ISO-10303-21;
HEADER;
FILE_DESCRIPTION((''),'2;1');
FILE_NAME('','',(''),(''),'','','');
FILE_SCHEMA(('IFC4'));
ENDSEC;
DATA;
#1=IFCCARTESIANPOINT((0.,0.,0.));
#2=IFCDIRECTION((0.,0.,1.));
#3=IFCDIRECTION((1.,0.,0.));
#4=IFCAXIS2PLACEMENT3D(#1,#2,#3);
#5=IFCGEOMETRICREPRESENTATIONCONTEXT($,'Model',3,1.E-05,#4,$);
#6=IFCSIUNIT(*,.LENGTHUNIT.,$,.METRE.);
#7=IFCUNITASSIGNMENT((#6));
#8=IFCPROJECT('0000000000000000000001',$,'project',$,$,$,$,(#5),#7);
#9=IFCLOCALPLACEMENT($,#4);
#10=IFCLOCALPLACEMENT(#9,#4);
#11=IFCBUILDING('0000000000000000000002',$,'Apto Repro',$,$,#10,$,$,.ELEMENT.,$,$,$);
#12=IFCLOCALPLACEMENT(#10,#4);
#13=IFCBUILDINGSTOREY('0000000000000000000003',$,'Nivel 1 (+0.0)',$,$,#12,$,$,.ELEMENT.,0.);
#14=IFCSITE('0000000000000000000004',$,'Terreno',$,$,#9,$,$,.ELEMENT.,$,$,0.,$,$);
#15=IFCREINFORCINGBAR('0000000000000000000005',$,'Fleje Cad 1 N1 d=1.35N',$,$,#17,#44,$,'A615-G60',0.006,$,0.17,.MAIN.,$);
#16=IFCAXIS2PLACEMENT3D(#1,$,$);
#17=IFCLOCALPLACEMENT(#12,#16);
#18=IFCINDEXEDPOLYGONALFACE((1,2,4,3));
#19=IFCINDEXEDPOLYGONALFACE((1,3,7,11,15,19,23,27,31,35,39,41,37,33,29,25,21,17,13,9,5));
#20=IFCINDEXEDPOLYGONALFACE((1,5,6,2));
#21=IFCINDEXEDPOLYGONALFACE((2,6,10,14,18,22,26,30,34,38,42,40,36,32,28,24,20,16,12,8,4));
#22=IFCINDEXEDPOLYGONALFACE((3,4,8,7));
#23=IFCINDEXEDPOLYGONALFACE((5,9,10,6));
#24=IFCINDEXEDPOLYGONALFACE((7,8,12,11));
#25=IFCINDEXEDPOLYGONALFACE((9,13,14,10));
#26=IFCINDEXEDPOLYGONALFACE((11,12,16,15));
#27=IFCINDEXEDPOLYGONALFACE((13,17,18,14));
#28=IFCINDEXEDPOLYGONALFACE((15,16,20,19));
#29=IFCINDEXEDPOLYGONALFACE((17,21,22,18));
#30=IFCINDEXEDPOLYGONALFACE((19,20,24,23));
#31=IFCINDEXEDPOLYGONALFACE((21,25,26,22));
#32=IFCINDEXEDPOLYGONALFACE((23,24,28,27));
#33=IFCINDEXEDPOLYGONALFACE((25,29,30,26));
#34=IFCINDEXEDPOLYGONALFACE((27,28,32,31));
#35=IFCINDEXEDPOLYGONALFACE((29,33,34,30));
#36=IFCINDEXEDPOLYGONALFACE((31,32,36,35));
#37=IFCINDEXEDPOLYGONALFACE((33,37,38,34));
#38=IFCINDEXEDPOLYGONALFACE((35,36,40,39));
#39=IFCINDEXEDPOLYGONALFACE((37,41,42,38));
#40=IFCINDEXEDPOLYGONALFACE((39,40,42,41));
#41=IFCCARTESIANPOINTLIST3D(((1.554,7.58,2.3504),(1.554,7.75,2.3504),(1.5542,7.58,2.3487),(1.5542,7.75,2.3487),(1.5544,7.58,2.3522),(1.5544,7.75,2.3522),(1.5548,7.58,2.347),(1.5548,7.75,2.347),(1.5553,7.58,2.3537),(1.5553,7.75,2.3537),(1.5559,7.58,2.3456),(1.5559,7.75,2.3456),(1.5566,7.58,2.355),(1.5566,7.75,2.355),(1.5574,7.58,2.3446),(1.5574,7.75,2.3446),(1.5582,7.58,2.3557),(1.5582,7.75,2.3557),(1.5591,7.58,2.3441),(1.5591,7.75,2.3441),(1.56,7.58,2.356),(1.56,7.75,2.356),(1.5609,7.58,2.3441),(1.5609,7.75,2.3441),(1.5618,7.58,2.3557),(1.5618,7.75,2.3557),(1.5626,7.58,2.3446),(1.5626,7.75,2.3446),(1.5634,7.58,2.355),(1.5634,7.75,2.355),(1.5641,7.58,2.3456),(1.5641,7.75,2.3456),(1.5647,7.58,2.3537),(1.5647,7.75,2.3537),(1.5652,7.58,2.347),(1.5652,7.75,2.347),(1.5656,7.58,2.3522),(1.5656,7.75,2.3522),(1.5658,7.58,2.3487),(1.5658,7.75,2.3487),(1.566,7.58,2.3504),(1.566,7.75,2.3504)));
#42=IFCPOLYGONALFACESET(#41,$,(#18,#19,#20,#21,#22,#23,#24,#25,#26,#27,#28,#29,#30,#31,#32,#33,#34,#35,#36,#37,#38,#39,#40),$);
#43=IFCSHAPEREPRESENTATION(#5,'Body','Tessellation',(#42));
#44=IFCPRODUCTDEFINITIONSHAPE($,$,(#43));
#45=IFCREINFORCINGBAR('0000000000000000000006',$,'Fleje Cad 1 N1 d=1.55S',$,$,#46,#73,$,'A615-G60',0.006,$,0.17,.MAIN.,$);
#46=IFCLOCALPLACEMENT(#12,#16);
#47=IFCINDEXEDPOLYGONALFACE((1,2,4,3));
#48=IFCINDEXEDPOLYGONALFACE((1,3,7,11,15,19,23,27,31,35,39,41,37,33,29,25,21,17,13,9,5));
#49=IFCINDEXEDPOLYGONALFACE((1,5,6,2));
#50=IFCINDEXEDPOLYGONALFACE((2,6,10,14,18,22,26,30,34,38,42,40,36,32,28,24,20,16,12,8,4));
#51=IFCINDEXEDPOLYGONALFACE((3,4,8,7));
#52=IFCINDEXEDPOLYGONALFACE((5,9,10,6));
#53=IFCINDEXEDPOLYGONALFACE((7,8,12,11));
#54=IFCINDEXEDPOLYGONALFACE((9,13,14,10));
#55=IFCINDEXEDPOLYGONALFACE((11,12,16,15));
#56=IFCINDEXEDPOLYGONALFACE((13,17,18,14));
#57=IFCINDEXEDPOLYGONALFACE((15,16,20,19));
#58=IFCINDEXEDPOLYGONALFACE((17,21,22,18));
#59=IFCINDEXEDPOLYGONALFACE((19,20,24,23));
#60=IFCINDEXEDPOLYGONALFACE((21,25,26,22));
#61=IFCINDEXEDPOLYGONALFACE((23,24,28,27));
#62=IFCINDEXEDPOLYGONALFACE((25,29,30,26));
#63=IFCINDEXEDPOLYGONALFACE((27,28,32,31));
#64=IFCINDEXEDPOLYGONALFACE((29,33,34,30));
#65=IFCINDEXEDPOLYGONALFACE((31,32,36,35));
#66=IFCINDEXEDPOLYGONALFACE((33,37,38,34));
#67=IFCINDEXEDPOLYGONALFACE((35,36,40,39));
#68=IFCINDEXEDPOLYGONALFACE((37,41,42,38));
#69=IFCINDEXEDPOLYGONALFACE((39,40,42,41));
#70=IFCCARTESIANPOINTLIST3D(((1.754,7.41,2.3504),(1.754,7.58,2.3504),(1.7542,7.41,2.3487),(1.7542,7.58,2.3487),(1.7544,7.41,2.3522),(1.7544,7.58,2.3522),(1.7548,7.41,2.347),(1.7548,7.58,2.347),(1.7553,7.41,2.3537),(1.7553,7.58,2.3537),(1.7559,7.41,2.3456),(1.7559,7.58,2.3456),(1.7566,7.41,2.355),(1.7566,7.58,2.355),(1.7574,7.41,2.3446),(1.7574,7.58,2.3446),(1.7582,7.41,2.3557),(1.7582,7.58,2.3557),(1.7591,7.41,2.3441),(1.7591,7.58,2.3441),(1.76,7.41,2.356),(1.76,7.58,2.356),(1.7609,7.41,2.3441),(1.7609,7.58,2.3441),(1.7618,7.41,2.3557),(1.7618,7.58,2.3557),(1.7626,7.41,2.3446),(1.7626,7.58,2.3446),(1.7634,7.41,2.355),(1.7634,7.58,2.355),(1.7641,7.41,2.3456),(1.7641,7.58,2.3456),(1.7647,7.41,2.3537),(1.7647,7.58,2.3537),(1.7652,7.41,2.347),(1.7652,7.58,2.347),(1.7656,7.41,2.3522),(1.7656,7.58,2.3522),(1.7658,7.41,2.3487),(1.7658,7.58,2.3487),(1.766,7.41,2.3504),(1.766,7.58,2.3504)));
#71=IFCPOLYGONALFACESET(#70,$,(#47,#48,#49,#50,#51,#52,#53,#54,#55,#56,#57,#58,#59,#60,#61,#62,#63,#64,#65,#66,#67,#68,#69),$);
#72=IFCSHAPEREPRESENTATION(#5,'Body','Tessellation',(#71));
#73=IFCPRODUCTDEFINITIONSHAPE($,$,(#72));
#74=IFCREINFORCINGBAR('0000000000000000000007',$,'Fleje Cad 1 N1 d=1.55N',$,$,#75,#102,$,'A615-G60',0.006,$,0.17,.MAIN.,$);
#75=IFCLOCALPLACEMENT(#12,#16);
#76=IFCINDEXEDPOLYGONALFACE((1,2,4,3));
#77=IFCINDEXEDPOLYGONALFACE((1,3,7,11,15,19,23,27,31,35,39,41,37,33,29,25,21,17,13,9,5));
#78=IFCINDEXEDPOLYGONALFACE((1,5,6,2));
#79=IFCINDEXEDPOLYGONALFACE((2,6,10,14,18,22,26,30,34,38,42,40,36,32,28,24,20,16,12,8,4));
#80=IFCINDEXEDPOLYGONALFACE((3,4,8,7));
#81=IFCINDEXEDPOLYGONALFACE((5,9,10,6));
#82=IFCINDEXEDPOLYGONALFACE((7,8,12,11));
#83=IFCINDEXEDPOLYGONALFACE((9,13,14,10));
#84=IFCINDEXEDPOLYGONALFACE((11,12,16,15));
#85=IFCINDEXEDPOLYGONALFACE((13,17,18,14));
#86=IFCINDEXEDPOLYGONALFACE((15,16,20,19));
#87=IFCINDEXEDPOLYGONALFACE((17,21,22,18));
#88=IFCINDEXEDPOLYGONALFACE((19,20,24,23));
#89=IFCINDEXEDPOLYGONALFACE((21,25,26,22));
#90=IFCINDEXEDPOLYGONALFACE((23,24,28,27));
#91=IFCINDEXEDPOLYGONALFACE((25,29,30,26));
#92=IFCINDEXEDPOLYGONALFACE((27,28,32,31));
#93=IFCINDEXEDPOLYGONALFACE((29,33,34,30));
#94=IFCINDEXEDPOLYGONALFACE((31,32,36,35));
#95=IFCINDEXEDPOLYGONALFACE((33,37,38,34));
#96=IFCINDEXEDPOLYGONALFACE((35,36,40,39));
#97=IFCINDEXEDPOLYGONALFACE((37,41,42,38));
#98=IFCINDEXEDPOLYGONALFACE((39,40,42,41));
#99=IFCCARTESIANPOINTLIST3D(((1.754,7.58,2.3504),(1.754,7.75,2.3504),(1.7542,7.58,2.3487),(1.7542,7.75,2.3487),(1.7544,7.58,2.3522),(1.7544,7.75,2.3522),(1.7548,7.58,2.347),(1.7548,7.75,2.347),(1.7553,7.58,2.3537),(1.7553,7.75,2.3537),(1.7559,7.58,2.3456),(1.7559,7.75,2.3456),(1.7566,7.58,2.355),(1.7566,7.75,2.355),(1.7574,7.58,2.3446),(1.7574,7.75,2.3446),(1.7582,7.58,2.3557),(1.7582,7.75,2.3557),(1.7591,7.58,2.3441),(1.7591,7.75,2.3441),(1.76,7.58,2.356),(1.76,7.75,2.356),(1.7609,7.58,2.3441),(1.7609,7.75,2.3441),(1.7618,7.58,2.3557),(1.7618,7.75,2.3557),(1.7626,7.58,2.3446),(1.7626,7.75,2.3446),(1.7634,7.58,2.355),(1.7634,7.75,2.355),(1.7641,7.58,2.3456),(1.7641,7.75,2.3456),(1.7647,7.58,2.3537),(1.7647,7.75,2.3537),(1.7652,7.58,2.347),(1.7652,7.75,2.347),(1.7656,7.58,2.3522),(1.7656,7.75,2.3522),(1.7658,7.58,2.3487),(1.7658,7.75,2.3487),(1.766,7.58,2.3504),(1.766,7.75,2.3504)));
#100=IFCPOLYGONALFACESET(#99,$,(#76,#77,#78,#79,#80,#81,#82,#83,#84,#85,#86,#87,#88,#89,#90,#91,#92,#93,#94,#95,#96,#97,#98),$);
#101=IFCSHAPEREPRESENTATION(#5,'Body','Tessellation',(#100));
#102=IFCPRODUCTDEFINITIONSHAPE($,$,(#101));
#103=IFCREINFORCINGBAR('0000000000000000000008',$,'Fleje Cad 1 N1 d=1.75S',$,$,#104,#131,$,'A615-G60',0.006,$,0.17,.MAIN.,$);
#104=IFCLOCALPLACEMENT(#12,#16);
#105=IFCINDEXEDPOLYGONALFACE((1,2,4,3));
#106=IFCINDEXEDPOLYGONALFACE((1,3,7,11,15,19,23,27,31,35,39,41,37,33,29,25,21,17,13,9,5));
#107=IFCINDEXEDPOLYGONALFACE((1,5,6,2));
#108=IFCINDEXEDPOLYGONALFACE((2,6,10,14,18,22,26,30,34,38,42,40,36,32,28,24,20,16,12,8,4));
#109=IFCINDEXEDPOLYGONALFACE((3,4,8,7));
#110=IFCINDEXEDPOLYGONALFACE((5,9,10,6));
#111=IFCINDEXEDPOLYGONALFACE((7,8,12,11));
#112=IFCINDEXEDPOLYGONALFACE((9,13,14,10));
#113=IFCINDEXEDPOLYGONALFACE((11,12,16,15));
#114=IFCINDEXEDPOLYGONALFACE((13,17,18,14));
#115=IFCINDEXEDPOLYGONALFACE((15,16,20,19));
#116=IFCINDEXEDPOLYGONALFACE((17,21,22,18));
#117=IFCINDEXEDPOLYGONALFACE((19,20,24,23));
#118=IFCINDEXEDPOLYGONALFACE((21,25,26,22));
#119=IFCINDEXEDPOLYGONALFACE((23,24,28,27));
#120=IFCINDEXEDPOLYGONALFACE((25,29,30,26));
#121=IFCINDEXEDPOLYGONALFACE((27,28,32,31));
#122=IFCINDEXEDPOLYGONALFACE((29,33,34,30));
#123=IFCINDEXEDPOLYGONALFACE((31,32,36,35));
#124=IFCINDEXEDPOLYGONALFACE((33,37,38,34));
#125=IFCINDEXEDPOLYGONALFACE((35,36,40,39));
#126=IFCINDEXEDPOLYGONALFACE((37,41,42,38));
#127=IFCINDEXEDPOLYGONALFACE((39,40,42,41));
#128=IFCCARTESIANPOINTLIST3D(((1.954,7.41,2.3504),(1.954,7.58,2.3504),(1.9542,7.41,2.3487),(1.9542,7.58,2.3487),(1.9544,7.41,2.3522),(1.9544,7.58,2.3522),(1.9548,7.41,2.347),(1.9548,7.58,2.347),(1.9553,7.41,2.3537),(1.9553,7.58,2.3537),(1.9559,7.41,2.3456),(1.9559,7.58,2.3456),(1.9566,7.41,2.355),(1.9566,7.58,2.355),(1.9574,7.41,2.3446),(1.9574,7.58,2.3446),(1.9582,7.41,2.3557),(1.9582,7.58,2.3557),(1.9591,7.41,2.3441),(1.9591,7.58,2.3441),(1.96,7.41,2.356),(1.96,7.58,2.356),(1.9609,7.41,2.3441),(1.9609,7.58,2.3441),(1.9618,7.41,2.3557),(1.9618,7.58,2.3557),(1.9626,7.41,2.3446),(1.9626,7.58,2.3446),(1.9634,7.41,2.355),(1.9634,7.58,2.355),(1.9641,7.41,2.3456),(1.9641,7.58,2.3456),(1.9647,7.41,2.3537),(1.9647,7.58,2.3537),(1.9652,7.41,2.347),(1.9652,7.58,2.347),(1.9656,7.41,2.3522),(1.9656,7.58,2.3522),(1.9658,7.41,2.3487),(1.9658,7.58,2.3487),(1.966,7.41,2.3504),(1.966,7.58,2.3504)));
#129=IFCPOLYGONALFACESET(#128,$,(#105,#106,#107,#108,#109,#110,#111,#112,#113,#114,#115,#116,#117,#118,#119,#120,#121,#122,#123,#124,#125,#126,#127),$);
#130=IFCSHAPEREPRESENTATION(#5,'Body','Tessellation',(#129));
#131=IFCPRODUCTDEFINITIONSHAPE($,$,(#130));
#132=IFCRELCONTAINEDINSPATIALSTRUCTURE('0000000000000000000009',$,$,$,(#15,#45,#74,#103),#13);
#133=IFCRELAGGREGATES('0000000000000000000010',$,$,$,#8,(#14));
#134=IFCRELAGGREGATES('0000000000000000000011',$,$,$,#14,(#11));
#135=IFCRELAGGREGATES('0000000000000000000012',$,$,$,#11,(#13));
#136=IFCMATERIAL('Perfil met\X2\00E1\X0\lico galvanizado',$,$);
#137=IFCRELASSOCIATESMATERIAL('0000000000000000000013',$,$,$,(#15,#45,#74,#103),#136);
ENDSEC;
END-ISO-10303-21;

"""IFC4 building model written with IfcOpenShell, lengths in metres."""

from ifc_helpers import new_model, si_unit, frame, origin_with_axes, origin_2d_with_axis, place, context, project, spatial, circle, extrude, material, element, save


model = new_model("IFC4")

# Units and contexts
model_context = context("Model", 3, precision=1e-05, world=origin_with_axes())
ifc_project = project(units=[si_unit("LENGTHUNIT", "METRE")], contexts=[model_context])

# Site, building, storey
site_placement = place(None, origin_with_axes())
site = spatial("IfcSite", under=ifc_project, at=site_placement, Name="Terreno", CompositionType="ELEMENT", RefElevation=0.0)
building_placement = place(site_placement, origin_with_axes())
building = spatial("IfcBuilding", under=site, at=building_placement, Name="Apto Repro", CompositionType="ELEMENT")
storey_placement = place(building_placement, origin_with_axes())
storey = spatial("IfcBuildingStorey", under=building, at=storey_placement, Name="Nivel 1 (+0.0)", CompositionType="ELEMENT", Elevation=0.0)

# Reinforcing bars
ifc_material = material(Name="Perfil metálico galvanizado")
reinforcing_bar_1_placement = place(storey_placement, origin_with_axes())
element("IfcReinforcingBar", 1, at=reinforcing_bar_1_placement, inside=storey, material=ifc_material, Name="Fleje Cad 1 N1 d=1.35N", SteelGrade="A615-G60", BarLength=0.17, NominalDiameter=0.006, PredefinedType="MAIN", context=model_context, shape_type="SweptSolid", body=[
    extrude(circle(Radius=0.006, at=origin_2d_with_axis()), frame((1.56, 7.58, 2.35), z_axis=(0.0, 1.0, 0.0), x_axis=(0.0, 0.0, 1.0)), (0.0, 0.0, 1.0), 0.17),
])
reinforcing_bar_2_placement = place(storey_placement, origin_with_axes())
element("IfcReinforcingBar", 2, at=reinforcing_bar_2_placement, inside=storey, material=ifc_material, Name="Fleje Cad 1 N1 d=1.55S", SteelGrade="A615-G60", BarLength=0.17, NominalDiameter=0.006, PredefinedType="MAIN", context=model_context, shape_type="SweptSolid", body=[
    extrude(circle(Radius=0.006, at=origin_2d_with_axis()), frame((1.76, 7.41, 2.35), z_axis=(0.0, 1.0, 0.0), x_axis=(0.0, 0.0, 1.0)), (0.0, 0.0, 1.0), 0.17),
])
reinforcing_bar_3_placement = place(storey_placement, origin_with_axes())
element("IfcReinforcingBar", 3, at=reinforcing_bar_3_placement, inside=storey, material=ifc_material, Name="Fleje Cad 1 N1 d=1.55N", SteelGrade="A615-G60", BarLength=0.17, NominalDiameter=0.006, PredefinedType="MAIN", context=model_context, shape_type="SweptSolid", body=[
    extrude(circle(Radius=0.006, at=origin_2d_with_axis()), frame((1.76, 7.58, 2.35), z_axis=(0.0, 1.0, 0.0), x_axis=(0.0, 0.0, 1.0)), (0.0, 0.0, 1.0), 0.17),
])
reinforcing_bar_4_placement = place(storey_placement, origin_with_axes())
element("IfcReinforcingBar", 4, at=reinforcing_bar_4_placement, inside=storey, material=ifc_material, Name="Fleje Cad 1 N1 d=1.75S", SteelGrade="A615-G60", BarLength=0.17, NominalDiameter=0.006, PredefinedType="MAIN", context=model_context, shape_type="SweptSolid", body=[
    extrude(circle(Radius=0.006, at=origin_2d_with_axis()), frame((1.96, 7.41, 2.35), z_axis=(0.0, 1.0, 0.0), x_axis=(0.0, 0.0, 1.0)), (0.0, 0.0, 1.0), 0.17),
])

save(model, "model.ifc")
